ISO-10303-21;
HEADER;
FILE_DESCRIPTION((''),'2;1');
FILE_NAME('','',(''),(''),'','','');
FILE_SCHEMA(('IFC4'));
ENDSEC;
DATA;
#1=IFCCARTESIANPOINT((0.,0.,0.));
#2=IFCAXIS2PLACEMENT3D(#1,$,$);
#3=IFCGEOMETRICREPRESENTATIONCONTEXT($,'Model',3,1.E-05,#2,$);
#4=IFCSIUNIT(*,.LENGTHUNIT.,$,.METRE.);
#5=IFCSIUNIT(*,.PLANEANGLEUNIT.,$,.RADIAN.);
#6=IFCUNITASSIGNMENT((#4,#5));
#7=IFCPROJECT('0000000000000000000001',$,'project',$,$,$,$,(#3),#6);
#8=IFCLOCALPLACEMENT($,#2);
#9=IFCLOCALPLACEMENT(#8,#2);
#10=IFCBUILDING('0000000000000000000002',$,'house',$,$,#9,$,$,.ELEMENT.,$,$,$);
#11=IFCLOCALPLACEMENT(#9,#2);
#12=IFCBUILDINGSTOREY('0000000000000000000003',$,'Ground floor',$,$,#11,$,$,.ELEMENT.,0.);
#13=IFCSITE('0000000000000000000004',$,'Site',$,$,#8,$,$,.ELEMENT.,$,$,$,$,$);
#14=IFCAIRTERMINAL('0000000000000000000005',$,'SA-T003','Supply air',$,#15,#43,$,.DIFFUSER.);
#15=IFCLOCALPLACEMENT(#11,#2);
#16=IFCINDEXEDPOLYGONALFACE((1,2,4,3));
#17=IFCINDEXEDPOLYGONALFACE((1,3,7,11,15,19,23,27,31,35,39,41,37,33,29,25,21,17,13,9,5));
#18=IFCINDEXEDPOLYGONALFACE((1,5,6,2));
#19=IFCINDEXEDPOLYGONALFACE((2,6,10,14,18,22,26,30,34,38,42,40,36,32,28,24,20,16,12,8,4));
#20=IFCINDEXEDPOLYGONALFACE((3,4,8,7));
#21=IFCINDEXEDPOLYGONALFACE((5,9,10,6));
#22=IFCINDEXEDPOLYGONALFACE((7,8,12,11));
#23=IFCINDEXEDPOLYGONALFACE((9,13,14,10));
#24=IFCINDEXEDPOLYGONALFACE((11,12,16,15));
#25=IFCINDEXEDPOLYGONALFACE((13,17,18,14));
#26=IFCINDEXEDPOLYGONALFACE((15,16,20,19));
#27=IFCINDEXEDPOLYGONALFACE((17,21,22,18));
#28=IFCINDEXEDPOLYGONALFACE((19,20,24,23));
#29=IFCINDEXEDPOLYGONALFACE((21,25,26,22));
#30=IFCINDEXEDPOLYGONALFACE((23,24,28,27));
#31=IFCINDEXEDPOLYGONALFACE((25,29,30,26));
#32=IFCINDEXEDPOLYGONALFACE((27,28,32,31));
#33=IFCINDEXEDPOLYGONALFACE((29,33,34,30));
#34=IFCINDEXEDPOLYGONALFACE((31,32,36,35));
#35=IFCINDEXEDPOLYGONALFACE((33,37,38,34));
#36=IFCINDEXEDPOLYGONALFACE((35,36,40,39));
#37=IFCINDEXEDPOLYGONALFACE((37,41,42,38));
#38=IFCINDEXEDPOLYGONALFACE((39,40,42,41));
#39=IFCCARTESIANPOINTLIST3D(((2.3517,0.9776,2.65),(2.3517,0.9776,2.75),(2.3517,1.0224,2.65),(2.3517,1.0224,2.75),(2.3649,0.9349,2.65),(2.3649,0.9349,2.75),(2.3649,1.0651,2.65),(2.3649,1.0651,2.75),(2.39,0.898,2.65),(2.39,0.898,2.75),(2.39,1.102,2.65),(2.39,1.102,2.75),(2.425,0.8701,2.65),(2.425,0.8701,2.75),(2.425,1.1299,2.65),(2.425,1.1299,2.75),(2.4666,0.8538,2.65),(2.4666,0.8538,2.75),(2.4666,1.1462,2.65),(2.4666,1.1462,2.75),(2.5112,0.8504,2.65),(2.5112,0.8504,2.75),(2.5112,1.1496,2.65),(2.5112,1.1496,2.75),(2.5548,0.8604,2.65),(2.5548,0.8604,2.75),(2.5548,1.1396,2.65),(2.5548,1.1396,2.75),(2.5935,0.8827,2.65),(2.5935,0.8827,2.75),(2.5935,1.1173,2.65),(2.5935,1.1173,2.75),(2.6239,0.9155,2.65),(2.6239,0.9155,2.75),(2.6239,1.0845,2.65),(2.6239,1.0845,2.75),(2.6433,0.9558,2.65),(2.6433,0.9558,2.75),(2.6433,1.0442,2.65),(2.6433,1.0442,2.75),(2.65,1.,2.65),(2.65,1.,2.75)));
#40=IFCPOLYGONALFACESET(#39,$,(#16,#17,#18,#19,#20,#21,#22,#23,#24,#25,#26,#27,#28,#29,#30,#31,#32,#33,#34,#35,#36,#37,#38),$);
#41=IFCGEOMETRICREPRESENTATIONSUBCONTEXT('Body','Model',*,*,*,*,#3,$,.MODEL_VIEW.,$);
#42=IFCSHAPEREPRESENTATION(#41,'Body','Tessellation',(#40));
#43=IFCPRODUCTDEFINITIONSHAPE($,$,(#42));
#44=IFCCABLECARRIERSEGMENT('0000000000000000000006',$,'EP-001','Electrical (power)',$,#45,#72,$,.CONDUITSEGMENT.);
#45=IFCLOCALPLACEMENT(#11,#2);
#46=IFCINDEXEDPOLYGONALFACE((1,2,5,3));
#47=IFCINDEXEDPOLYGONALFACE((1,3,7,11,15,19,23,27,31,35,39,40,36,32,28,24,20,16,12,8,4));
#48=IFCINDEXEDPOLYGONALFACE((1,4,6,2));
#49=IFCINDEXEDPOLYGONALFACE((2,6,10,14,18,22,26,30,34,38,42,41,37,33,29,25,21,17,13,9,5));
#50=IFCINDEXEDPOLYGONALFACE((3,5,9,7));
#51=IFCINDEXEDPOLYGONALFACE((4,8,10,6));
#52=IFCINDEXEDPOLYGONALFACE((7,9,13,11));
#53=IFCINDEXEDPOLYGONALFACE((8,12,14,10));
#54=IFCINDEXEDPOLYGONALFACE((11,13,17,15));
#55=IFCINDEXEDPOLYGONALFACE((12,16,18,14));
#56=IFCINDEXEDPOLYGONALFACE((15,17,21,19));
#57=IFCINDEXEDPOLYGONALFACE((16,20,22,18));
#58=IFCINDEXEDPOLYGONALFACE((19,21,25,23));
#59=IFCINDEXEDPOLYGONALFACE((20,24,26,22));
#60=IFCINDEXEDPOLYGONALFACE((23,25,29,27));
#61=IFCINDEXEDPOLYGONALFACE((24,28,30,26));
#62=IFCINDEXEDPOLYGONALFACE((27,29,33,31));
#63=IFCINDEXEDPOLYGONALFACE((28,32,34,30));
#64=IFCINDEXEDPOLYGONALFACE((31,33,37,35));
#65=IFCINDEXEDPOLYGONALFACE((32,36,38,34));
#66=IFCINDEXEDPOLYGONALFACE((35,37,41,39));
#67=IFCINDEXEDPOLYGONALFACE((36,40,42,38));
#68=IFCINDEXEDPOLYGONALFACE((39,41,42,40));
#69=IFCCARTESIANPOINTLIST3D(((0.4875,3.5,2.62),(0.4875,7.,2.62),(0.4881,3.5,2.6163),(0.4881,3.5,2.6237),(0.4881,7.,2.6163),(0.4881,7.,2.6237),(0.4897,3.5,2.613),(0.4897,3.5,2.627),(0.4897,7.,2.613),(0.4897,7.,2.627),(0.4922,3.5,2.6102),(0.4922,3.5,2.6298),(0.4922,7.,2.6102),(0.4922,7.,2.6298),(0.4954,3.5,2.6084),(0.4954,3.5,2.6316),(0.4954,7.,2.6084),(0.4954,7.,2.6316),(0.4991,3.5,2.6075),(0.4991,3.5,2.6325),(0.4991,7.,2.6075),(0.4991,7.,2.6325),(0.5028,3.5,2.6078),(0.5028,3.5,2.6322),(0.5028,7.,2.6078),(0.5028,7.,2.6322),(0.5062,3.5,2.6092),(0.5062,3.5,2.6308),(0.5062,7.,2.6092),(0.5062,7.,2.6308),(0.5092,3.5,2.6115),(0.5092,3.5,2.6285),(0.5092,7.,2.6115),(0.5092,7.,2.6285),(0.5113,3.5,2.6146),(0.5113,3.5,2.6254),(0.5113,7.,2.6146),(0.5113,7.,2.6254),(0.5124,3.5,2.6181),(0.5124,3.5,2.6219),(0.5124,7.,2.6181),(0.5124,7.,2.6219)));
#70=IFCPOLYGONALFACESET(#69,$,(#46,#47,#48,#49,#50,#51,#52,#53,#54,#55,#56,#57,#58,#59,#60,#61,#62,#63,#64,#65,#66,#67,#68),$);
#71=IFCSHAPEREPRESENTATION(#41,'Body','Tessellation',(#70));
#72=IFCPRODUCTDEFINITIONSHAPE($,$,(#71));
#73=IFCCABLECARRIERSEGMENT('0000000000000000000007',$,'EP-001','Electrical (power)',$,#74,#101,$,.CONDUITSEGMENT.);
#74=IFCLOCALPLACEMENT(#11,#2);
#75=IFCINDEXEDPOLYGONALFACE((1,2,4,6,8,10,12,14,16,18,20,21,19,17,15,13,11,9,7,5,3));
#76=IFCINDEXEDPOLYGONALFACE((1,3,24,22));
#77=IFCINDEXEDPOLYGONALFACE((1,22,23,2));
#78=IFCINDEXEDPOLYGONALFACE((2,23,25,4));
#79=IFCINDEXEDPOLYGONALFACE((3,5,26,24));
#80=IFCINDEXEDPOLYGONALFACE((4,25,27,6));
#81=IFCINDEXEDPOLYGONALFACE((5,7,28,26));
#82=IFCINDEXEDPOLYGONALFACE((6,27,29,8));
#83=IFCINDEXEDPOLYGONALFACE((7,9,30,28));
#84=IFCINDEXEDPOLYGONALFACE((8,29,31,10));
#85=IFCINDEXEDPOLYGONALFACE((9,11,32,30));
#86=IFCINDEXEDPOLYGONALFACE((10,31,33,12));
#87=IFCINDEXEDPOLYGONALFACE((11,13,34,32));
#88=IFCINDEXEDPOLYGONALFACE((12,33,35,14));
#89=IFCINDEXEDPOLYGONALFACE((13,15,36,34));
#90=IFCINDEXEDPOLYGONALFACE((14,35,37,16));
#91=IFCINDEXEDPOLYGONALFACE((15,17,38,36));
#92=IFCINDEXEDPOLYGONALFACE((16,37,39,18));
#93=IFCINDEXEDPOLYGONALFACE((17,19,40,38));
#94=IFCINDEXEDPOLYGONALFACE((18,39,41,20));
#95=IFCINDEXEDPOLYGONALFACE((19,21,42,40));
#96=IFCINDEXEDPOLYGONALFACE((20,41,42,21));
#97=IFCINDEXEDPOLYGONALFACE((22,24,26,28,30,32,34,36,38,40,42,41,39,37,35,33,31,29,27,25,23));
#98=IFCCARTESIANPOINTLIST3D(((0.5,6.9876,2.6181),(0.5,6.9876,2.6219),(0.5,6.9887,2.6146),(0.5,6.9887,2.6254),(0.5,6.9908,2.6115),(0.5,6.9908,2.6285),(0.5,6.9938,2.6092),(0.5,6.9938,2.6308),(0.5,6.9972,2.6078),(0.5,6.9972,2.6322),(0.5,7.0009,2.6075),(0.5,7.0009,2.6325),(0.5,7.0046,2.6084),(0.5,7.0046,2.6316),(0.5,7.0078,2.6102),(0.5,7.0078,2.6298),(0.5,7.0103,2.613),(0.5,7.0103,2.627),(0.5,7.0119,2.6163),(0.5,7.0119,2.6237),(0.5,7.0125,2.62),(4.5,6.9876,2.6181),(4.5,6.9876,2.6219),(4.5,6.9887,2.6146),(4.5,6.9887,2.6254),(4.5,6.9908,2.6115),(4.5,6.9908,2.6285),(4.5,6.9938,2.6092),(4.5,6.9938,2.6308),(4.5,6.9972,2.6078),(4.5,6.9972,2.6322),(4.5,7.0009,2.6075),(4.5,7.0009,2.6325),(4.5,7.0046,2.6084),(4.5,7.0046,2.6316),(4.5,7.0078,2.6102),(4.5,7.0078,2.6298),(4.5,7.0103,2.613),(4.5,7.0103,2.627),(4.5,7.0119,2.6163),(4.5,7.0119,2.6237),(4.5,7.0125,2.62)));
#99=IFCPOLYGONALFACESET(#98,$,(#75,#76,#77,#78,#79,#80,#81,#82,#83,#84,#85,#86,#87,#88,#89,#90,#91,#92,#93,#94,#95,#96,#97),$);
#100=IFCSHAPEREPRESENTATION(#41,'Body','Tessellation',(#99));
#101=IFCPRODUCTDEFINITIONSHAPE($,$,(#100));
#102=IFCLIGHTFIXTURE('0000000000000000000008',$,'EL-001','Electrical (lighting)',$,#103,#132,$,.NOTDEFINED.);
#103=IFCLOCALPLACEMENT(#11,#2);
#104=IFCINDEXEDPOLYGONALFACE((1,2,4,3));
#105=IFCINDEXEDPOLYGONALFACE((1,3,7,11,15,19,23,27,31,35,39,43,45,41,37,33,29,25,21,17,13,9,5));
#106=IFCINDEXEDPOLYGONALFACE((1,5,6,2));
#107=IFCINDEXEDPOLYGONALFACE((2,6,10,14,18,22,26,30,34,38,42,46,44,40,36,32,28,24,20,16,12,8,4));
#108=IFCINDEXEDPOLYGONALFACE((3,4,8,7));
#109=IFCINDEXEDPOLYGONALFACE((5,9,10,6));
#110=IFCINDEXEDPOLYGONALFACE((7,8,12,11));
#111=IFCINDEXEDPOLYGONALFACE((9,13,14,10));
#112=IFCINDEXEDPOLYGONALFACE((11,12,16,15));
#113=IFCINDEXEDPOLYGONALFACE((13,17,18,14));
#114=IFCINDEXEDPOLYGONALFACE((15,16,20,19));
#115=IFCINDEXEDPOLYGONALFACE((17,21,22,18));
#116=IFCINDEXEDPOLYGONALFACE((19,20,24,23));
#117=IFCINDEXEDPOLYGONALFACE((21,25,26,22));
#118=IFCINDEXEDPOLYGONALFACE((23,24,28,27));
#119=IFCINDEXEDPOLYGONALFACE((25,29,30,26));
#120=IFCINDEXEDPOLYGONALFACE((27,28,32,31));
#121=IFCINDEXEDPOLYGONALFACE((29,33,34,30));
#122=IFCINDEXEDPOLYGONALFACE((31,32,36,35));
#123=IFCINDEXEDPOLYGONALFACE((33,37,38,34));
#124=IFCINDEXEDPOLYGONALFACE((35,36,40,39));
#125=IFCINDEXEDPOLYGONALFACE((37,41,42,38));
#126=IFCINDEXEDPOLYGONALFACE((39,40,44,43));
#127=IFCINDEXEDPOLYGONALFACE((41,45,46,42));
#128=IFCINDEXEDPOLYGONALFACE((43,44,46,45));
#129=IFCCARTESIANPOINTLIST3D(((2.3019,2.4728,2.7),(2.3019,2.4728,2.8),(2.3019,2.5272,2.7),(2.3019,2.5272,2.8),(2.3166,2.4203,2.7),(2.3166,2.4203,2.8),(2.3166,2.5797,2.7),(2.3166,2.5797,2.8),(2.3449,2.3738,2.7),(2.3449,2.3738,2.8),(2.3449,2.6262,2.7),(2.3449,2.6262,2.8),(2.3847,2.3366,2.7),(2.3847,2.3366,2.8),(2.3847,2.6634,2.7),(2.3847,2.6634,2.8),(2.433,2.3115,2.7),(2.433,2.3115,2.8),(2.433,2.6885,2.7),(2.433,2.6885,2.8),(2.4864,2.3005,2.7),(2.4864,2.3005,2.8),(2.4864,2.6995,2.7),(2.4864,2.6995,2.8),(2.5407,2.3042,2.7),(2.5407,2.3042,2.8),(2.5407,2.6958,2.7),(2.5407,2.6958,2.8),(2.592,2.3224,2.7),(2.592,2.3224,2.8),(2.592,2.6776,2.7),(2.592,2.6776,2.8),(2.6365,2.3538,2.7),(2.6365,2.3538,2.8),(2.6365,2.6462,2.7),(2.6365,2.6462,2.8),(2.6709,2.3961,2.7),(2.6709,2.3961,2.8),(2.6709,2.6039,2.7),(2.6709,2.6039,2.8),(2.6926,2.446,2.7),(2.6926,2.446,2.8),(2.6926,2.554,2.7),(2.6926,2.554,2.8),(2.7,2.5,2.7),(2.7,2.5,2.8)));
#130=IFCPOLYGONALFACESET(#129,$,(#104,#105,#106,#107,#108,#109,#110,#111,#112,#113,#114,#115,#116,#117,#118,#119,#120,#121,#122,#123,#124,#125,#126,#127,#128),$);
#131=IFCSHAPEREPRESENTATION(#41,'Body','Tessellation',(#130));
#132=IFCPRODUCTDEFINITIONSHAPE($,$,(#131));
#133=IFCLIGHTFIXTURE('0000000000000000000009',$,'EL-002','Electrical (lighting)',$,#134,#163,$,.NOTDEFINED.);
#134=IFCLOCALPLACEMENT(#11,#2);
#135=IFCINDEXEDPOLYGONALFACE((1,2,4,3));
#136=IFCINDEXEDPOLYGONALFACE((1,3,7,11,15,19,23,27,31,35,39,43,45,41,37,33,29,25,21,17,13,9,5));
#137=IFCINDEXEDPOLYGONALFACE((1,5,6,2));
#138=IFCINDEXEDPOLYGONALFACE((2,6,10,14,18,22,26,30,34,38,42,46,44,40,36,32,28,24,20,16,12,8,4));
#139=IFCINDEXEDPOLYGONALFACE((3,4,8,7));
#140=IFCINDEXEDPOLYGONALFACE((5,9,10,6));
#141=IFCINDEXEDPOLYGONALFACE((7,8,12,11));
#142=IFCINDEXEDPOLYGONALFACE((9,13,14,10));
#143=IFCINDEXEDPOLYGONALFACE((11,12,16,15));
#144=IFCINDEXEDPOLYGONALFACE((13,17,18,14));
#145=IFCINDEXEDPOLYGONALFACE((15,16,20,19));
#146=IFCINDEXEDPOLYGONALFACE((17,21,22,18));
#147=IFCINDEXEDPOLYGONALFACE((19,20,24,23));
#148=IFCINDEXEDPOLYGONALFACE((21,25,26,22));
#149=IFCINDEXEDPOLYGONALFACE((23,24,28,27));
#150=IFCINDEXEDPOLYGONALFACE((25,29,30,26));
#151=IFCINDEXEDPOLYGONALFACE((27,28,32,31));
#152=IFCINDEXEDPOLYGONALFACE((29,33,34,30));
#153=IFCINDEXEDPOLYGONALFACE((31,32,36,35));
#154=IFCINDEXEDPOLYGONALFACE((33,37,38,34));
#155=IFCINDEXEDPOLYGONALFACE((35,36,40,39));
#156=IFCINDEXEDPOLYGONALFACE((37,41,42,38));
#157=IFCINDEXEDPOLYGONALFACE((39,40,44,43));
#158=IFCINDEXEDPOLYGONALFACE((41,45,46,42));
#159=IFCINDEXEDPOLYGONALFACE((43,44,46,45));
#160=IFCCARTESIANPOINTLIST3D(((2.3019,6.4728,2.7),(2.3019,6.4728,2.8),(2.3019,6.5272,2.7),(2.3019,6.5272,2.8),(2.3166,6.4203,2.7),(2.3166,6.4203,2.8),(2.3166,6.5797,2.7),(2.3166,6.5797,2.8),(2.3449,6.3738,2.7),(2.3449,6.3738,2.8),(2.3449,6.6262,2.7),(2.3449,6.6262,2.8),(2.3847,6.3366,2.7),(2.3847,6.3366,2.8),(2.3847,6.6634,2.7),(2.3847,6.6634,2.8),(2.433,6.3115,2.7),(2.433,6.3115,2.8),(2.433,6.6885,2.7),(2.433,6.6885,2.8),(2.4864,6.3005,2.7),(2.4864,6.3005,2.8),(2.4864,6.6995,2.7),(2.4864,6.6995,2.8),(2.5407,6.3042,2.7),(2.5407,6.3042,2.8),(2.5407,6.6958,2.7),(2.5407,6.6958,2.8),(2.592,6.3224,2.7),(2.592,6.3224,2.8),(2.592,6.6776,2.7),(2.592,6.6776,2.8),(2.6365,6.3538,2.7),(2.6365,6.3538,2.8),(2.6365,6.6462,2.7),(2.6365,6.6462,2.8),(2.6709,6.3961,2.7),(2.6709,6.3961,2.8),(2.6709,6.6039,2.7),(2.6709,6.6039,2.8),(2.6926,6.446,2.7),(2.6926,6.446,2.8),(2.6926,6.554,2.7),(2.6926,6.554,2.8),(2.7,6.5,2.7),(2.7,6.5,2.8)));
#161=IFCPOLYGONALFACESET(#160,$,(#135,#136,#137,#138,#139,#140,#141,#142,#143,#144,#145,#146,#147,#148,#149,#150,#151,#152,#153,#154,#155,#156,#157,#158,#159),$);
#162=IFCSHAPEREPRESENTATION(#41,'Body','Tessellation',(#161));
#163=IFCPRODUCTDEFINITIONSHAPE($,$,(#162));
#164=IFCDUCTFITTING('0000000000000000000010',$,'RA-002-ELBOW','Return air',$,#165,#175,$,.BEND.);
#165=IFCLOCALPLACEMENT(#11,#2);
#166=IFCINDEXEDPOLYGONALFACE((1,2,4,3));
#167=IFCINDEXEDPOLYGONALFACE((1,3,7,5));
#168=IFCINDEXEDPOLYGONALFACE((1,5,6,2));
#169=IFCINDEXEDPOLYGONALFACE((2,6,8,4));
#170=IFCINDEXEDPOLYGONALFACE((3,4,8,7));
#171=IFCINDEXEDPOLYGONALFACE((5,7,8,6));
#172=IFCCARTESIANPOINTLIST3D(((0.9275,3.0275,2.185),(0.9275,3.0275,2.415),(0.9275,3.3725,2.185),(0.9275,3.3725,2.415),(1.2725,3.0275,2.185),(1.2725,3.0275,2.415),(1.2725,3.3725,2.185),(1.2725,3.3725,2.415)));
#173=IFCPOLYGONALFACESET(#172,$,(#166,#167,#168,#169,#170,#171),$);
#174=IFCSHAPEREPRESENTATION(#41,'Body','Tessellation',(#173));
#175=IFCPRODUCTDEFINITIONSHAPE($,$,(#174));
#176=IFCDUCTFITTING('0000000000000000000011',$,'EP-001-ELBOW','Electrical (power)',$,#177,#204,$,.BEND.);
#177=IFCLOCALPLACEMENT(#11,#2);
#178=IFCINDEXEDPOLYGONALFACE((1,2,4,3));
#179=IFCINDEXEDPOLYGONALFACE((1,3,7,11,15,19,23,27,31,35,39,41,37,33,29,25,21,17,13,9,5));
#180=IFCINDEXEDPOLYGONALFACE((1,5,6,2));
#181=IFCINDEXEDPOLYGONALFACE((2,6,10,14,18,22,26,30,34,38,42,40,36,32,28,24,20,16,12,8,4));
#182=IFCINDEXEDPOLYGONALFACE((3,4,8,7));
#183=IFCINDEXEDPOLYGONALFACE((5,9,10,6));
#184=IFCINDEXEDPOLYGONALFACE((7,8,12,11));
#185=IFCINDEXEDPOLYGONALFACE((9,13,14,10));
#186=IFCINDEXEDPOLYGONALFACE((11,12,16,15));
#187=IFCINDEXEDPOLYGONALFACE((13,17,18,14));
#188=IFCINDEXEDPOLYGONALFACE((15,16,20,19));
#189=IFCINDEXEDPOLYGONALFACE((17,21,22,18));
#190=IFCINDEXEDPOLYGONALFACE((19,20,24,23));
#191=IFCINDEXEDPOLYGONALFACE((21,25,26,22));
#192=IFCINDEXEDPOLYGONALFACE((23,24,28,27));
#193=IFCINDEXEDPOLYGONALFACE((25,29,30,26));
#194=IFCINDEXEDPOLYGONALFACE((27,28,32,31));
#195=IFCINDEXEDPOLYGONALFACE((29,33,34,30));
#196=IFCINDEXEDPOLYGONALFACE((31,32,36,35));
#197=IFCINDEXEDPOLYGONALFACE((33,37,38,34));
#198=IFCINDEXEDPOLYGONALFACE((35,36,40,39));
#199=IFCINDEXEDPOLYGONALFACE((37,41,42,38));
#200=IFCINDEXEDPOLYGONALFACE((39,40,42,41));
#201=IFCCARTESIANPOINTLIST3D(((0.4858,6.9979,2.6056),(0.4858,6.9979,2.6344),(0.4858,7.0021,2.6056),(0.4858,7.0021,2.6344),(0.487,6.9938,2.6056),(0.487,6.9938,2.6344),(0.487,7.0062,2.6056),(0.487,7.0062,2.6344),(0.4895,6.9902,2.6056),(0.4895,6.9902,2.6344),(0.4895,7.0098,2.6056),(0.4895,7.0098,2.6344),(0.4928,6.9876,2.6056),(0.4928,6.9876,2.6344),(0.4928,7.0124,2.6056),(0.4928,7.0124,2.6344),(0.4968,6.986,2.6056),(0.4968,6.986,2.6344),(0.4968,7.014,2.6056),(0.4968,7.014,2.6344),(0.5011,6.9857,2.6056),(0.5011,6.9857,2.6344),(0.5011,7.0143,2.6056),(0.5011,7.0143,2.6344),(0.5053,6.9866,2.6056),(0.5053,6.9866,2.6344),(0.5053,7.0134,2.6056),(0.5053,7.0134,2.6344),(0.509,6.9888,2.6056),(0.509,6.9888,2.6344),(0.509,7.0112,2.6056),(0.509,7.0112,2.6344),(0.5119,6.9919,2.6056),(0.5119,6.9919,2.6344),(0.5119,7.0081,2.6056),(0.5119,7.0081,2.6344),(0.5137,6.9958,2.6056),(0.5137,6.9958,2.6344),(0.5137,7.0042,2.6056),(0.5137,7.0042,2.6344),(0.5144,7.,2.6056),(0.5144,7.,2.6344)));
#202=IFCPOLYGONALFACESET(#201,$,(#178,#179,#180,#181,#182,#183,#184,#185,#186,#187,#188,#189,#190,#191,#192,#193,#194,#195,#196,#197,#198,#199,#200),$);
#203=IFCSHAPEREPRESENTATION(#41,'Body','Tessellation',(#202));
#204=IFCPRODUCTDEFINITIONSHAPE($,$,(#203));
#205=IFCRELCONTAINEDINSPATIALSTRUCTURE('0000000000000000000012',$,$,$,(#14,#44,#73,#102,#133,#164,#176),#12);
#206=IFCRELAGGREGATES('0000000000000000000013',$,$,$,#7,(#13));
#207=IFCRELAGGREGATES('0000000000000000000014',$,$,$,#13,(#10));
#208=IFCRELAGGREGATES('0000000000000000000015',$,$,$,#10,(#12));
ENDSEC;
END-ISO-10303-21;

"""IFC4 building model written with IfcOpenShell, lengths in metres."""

from ifc_helpers import new_model, si_unit, frame, origin, origin_2d, place, context, subcontext, project, spatial, rectangle, circle, extrude, element, save


model = new_model("IFC4")

# Units and contexts
model_context = context("Model", 3, precision=1e-05, world=origin())
body_context = subcontext(model_context, "Body", "Model", "MODEL_VIEW")
ifc_project = project(units=[si_unit("LENGTHUNIT", "METRE"), si_unit("PLANEANGLEUNIT", "RADIAN")], contexts=[model_context])

# Site, building, storey
site_placement = place(None, origin())
site = spatial("IfcSite", under=ifc_project, at=site_placement, Name="Site", CompositionType="ELEMENT")
building_placement = place(site_placement, origin())
building = spatial("IfcBuilding", under=site, at=building_placement, Name="house", CompositionType="ELEMENT")
storey_placement = place(building_placement, origin())
storey = spatial("IfcBuildingStorey", under=building, at=storey_placement, Name="Ground floor", CompositionType="ELEMENT", Elevation=0.0)

# Air terminal
air_terminal_placement = place(storey_placement, frame((2.5, 1.0, 2.65), z_axis=(0.0, 0.0, 1.0), x_axis=(1.0, 0.0, 0.0)))
element("IfcAirTerminal", 1, at=air_terminal_placement, inside=storey, Name="SA-T003", Description="Supply air", PredefinedType="DIFFUSER", context=body_context, shape_type="SweptSolid", body=[
    extrude(circle(Radius=0.15, at=origin_2d()), origin(), (0.0, 0.0, 1.0), 0.1),
])

# Cable carrier segments
cable_carrier_segment_1_placement = place(storey_placement, frame((0.5, 3.5, 2.62), z_axis=(0.0, 1.0, 0.0), x_axis=(-1.0, 0.0, 0.0)))
element("IfcCableCarrierSegment", 2, at=cable_carrier_segment_1_placement, inside=storey, Name="EP-001", Description="Electrical (power)", PredefinedType="CONDUITSEGMENT", context=body_context, shape_type="SweptSolid", body=[
    extrude(circle(Radius=0.0125, at=origin_2d()), origin(), (0.0, 0.0, 1.0), 3.5),
])
cable_carrier_segment_2_placement = place(storey_placement, frame((0.5, 7.0, 2.62), z_axis=(1.0, 0.0, 0.0), x_axis=(0.0, 1.0, 0.0)))
element("IfcCableCarrierSegment", 3, at=cable_carrier_segment_2_placement, inside=storey, Name="EP-001", Description="Electrical (power)", PredefinedType="CONDUITSEGMENT", context=body_context, shape_type="SweptSolid", body=[
    extrude(circle(Radius=0.0125, at=origin_2d()), origin(), (0.0, 0.0, 1.0), 4.0),
])

# Light fixtures
for number, where, z_axis, x_axis, name in (
    (4, (2.5, 2.5, 2.7), (0.0, 0.0, 1.0), (1.0, 0.0, 0.0), "EL-001"),
    (5, (2.5, 6.5, 2.7), (0.0, 0.0, 1.0), (1.0, 0.0, 0.0), "EL-002"),
):
    element("IfcLightFixture", number, at=place(storey_placement, frame(where, z_axis=z_axis, x_axis=x_axis)), inside=storey, Name=name, Description="Electrical (lighting)", PredefinedType="NOTDEFINED", context=body_context, shape_type="SweptSolid", body=[
        extrude(circle(Radius=0.2, at=origin_2d()), origin(), (0.0, 0.0, 1.0), 0.1),
    ])

# Duct fittings
duct_fitting_1_placement = place(storey_placement, frame((1.1, 3.2, 2.185), z_axis=(0.0, 0.0, 1.0), x_axis=(1.0, 0.0, 0.0)))
element("IfcDuctFitting", 6, at=duct_fitting_1_placement, inside=storey, Name="RA-002-ELBOW", Description="Return air", PredefinedType="BEND", context=body_context, shape_type="SweptSolid", body=[
    extrude(rectangle(XDim=0.345, YDim=0.345, at=origin_2d()), origin(), (0.0, 0.0, 1.0), 0.23),
])
duct_fitting_2_placement = place(storey_placement, frame((0.5, 7.0, 2.6056), z_axis=(0.0, 0.0, 1.0), x_axis=(1.0, 0.0, 0.0)))
element("IfcDuctFitting", 7, at=duct_fitting_2_placement, inside=storey, Name="EP-001-ELBOW", Description="Electrical (power)", PredefinedType="BEND", context=body_context, shape_type="SweptSolid", body=[
    extrude(circle(Radius=0.0144, at=origin_2d()), origin(), (0.0, 0.0, 1.0), 0.0288),
])

save(model, "model.ifc")
